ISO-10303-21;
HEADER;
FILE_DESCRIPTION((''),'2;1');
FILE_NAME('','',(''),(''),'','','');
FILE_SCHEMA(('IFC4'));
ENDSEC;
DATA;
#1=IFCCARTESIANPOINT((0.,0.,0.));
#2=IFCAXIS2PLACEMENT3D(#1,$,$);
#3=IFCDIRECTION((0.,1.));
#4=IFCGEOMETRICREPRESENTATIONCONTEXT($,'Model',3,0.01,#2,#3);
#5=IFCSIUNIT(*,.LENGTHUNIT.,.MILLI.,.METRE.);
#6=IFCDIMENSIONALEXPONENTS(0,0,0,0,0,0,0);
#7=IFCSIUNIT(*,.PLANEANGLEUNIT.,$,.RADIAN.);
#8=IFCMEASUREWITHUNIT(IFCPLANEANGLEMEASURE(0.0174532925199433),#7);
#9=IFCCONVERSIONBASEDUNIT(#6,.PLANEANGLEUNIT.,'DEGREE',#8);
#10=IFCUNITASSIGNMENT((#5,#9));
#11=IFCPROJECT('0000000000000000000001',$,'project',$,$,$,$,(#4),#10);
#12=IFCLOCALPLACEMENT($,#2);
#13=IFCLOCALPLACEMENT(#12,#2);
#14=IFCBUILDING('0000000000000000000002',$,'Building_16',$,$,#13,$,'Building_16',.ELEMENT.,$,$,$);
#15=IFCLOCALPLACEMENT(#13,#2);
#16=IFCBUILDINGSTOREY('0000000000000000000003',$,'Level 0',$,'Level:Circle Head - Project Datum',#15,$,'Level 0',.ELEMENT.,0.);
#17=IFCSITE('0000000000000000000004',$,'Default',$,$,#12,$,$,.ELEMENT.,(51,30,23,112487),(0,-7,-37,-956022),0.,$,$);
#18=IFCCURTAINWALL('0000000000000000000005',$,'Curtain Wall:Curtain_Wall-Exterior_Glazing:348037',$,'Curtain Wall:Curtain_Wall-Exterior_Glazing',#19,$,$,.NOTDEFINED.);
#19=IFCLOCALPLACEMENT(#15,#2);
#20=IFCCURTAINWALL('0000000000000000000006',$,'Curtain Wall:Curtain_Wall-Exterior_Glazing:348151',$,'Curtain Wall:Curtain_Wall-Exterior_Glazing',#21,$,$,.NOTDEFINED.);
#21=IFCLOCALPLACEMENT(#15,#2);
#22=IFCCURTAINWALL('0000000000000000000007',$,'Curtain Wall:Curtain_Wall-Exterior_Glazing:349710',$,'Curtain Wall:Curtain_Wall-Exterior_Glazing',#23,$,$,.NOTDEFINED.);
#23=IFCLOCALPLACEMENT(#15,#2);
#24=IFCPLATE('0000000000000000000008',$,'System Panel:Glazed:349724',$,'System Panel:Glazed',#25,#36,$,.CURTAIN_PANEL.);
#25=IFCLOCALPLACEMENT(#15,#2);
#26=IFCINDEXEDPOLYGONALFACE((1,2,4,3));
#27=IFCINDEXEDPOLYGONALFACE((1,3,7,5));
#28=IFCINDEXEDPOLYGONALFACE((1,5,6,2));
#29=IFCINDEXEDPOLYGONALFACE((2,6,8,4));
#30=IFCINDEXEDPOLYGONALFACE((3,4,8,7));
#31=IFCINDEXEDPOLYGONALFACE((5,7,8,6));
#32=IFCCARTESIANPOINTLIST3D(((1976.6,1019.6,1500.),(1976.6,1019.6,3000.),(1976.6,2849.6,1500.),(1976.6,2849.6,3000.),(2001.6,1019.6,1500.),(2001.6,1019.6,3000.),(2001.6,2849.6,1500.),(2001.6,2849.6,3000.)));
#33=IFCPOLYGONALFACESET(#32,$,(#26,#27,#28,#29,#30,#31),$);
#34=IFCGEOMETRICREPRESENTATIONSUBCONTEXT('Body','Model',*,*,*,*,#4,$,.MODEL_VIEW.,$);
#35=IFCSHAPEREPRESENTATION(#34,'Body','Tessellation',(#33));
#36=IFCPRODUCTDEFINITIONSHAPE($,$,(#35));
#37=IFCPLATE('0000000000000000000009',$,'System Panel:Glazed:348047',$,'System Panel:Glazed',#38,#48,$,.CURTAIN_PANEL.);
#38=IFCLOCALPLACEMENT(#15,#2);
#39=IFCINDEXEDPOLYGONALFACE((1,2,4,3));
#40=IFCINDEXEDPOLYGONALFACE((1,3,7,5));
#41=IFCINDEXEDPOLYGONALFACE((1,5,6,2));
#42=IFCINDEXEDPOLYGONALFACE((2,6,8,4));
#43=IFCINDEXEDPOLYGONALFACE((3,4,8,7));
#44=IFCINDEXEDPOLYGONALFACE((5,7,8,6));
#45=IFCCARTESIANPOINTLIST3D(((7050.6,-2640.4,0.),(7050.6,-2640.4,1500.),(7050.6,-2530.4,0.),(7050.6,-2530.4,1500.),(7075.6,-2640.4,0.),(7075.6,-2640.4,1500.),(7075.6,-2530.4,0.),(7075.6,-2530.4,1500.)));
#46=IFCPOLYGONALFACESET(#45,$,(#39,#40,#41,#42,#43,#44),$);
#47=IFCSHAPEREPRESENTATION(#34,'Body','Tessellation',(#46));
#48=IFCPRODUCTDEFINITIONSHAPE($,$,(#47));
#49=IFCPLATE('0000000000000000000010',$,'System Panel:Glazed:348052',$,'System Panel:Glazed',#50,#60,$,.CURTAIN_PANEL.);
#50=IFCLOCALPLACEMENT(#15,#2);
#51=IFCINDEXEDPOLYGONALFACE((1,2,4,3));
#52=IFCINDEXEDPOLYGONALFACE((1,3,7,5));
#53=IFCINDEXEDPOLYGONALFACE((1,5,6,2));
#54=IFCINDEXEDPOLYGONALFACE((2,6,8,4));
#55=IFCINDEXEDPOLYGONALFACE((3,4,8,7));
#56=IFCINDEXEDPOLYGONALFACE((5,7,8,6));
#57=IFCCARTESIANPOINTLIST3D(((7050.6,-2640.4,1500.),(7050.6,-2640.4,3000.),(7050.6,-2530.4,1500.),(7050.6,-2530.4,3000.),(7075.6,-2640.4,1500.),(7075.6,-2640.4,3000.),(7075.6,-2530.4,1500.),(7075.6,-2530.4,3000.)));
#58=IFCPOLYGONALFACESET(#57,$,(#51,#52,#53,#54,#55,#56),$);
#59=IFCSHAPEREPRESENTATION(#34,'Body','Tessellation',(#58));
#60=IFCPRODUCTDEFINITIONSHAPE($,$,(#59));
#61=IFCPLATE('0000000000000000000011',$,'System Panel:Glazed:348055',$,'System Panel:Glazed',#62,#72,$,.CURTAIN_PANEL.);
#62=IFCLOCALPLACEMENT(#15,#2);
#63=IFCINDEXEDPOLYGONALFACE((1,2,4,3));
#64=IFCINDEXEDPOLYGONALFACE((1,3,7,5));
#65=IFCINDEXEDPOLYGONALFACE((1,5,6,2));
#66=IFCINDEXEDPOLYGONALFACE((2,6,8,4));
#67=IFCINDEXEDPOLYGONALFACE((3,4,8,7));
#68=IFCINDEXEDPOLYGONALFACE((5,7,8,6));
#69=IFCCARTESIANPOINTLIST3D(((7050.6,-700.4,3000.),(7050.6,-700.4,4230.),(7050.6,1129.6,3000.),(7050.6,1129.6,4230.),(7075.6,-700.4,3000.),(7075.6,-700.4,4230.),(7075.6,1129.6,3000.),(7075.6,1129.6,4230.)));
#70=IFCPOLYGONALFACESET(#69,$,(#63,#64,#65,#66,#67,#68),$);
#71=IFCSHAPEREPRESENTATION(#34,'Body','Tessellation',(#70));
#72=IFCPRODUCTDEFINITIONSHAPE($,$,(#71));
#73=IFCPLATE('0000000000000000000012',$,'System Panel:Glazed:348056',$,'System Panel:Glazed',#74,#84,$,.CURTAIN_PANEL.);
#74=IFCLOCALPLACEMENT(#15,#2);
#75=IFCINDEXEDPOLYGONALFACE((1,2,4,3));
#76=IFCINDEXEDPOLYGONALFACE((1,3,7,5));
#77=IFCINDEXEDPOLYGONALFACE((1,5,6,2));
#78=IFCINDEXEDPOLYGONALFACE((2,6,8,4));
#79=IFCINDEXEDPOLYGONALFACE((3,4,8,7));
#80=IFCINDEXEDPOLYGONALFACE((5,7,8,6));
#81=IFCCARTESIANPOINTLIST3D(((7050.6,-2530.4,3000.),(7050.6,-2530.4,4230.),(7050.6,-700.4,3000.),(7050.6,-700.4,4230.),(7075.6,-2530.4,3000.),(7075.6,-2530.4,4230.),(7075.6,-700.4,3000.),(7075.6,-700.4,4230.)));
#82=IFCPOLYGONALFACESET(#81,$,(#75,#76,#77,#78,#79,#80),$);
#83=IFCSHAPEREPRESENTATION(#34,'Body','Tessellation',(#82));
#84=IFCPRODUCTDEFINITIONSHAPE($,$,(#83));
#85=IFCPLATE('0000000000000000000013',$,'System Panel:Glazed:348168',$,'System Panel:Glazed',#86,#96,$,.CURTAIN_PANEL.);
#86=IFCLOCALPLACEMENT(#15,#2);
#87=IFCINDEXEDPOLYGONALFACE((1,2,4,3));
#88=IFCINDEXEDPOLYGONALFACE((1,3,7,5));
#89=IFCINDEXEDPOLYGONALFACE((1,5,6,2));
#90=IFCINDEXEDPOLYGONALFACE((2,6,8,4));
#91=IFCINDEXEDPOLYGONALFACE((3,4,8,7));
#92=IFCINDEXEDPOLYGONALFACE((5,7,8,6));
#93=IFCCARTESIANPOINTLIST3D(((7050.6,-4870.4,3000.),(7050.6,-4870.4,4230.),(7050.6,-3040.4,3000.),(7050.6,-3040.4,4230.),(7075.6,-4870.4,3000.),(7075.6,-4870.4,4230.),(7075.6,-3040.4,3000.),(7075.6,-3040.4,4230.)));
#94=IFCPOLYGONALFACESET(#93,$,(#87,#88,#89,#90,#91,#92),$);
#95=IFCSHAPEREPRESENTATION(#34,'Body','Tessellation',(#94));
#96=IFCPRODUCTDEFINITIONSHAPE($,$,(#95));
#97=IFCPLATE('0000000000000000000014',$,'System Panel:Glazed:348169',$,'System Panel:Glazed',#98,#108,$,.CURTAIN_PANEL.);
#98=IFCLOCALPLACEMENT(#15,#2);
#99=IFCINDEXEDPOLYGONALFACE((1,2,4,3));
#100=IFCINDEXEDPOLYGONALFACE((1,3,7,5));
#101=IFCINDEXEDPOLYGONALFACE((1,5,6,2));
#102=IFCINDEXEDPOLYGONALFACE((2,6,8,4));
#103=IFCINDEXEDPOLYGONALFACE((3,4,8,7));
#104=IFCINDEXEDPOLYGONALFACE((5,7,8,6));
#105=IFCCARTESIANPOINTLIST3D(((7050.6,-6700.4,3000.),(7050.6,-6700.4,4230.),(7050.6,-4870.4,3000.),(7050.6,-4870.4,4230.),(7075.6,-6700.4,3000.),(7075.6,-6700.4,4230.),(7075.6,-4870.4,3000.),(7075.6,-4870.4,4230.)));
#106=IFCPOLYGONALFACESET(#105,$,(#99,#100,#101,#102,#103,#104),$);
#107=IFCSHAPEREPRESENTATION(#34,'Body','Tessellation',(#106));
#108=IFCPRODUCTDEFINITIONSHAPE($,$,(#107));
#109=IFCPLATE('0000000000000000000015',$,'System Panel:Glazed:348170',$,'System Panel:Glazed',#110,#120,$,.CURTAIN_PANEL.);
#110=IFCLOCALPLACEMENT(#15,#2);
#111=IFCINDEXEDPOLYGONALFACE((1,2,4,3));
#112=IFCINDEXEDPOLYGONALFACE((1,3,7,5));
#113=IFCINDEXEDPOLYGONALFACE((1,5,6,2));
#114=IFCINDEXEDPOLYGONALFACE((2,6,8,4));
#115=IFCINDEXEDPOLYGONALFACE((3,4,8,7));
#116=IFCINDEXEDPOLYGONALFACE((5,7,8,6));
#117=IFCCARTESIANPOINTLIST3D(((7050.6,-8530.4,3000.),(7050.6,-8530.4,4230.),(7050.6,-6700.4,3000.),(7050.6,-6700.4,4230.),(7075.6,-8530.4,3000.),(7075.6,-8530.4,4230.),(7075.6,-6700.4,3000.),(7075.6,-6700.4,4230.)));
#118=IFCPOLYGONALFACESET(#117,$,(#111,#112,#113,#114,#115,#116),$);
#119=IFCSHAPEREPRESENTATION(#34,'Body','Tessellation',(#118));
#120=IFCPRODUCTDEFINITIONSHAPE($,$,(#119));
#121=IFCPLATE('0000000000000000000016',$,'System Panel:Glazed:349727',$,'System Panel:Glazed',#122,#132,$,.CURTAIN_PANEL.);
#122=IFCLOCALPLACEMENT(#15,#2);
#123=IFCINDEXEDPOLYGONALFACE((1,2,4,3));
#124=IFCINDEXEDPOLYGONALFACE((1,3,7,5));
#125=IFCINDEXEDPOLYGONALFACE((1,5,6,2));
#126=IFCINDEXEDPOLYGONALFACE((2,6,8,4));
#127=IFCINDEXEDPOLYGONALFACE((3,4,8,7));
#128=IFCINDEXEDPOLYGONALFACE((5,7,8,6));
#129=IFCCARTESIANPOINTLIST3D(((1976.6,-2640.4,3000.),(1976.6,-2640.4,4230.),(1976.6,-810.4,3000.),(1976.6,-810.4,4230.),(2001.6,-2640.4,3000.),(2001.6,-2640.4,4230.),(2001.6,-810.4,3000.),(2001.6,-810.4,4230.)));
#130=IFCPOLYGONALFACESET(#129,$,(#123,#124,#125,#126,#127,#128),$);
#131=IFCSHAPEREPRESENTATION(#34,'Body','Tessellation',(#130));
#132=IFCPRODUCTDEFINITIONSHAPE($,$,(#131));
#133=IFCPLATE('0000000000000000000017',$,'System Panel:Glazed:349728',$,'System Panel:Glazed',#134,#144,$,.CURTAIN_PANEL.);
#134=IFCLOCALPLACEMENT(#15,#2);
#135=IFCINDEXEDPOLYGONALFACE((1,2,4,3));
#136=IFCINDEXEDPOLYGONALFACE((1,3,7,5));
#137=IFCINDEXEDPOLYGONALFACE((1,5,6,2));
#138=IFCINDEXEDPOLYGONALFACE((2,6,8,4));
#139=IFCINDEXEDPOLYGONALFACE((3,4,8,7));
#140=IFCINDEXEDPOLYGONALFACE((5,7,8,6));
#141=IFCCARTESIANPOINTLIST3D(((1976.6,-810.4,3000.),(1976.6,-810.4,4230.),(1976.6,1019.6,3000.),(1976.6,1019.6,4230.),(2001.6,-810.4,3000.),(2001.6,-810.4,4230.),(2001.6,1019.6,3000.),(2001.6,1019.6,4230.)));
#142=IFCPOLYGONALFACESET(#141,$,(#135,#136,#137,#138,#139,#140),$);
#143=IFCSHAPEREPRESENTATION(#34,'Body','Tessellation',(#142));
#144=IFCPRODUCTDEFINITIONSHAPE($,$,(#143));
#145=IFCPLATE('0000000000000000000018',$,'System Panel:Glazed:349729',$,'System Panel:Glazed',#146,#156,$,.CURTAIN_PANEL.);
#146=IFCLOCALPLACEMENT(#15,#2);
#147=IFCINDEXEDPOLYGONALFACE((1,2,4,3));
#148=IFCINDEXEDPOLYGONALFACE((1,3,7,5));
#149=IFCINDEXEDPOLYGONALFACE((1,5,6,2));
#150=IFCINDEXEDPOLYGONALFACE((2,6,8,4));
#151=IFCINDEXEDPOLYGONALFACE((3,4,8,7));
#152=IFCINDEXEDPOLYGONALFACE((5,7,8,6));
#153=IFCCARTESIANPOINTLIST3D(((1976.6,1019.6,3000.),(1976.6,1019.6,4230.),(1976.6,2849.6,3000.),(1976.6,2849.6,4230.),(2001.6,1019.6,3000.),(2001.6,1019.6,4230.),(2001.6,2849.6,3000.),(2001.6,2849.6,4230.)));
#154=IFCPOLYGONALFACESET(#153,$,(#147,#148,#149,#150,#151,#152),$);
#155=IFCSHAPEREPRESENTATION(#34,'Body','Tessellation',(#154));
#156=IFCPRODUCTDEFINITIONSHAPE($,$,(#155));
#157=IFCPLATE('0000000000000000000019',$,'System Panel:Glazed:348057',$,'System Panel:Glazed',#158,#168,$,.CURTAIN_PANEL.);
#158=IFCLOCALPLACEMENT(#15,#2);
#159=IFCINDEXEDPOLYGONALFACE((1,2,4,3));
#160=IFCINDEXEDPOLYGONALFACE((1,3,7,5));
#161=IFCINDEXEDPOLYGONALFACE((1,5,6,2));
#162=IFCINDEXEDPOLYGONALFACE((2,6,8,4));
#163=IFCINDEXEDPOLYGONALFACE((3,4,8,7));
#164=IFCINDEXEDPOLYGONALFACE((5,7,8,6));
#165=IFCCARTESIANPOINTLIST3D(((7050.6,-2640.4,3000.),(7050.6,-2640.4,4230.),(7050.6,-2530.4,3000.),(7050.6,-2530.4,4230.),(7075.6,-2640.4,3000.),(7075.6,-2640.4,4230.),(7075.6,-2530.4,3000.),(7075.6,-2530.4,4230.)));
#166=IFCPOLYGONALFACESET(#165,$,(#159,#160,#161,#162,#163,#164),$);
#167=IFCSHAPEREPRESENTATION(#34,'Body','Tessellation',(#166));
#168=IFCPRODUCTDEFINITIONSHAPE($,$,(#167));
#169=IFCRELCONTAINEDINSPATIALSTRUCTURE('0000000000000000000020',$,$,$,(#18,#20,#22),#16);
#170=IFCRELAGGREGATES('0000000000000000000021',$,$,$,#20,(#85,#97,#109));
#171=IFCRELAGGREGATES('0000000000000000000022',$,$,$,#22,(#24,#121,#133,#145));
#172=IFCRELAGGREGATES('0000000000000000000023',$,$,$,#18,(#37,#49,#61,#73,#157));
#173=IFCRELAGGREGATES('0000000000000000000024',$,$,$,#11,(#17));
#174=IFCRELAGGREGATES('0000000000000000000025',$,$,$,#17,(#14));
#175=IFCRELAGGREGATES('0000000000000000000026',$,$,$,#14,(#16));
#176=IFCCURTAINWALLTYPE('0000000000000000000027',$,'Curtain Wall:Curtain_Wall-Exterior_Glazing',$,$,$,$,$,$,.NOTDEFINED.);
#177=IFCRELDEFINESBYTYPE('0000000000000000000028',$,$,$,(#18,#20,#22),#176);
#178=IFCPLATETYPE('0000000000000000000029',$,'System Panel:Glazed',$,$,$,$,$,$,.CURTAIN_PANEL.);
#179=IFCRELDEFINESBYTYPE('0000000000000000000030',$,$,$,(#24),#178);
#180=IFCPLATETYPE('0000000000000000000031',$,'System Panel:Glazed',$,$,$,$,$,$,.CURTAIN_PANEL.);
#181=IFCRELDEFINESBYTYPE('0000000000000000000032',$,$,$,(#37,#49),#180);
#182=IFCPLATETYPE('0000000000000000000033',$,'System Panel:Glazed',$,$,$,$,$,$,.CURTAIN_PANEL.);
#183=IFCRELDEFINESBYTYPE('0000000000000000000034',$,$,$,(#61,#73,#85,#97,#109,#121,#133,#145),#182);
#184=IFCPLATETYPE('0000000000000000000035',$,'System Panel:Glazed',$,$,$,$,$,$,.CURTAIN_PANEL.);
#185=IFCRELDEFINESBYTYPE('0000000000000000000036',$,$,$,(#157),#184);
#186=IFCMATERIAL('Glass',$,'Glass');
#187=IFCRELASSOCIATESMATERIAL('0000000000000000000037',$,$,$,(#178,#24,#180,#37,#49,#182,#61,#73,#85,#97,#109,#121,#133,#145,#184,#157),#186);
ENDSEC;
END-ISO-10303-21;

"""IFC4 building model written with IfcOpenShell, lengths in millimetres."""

from ifc_helpers import new_model, entity, si_unit, converted_unit, direction, frame, origin, place, context, subcontext, project, spatial, indexed_curve, outline, extrude, source, transform, mapped, material, type_object, type_shapes, element, aggregate, save


model = new_model("IFC4")

# Units and contexts
model_context = context("Model", 3, precision=0.01, world=origin(), true_north=direction((0.0, 1.0)))
body_context = subcontext(model_context, "Body", "Model", "MODEL_VIEW")
ifc_project = project(units=[si_unit("LENGTHUNIT", "METRE", prefix="MILLI"), converted_unit("PLANEANGLEUNIT", "DEGREE", entity("IfcPlaneAngleMeasure", 0.0174532925199433), si_unit("PLANEANGLEUNIT", "RADIAN"), dimensions=[0, 0, 0, 0, 0, 0, 0])], contexts=[model_context])

# Site, building, storey
site_placement = place(None, origin())
site = spatial("IfcSite", under=ifc_project, at=site_placement, Name="Default", CompositionType="ELEMENT", RefLatitude=(51, 30, 23, 112487), RefLongitude=(0, -7, -37, -956022), RefElevation=0.0)
building_placement = place(site_placement, origin())
building = spatial("IfcBuilding", under=site, at=building_placement, Name="Building_16", LongName="Building_16", CompositionType="ELEMENT")
storey_placement = place(building_placement, origin())
storey = spatial("IfcBuildingStorey", under=building, at=storey_placement, Name="Level 0", ObjectType="Level:Circle Head - Project Datum", LongName="Level 0", CompositionType="ELEMENT", Elevation=0.0)

# Curtain walls, plate
curtain_wall_type = type_object("IfcCurtainWallType", Name="Curtain Wall:Curtain_Wall-Exterior_Glazing", PredefinedType="NOTDEFINED")
curtain_wall_1_placement = place(storey_placement, origin())
curtain_wall_1 = element("IfcCurtainWall", 1, at=curtain_wall_1_placement, inside=storey, type_object=curtain_wall_type, Name="Curtain Wall:Curtain_Wall-Exterior_Glazing:348037", ObjectType="Curtain Wall:Curtain_Wall-Exterior_Glazing", PredefinedType="NOTDEFINED")
ifc_material_1 = material(Name="Glass", Category="Glass")
plate_type_1 = type_object("IfcPlateType", Name="System Panel:Glazed", PredefinedType="CURTAIN_PANEL", material=ifc_material_1)
shared_shape_1 = source(origin(), body_context, "Body", "SweptSolid", [
    extrude(outline(indexed_curve([(-12.5, -915.0), (12.5, -915.0), (12.5, 915.0), (-12.5, 915.0), (-12.5, -915.0)], self_intersect=False)), frame((0.0, 37.0, 0.0), z_axis=(0.0, 0.0, 1.0), x_axis=(0.0, 1.0, 0.0)), (0.0, 0.0, 1.0), 1500.0),
])
type_shapes(plate_type_1, [shared_shape_1])
curtain_wall_2_placement = place(storey_placement, origin())
curtain_wall_2 = element("IfcCurtainWall", 2, at=curtain_wall_2_placement, inside=storey, type_object=curtain_wall_type, Name="Curtain Wall:Curtain_Wall-Exterior_Glazing:348151", ObjectType="Curtain Wall:Curtain_Wall-Exterior_Glazing", PredefinedType="NOTDEFINED")
curtain_wall_3_placement = place(storey_placement, origin())
curtain_wall_3 = element("IfcCurtainWall", 3, at=curtain_wall_3_placement, inside=storey, type_object=curtain_wall_type, Name="Curtain Wall:Curtain_Wall-Exterior_Glazing:349710", ObjectType="Curtain Wall:Curtain_Wall-Exterior_Glazing", PredefinedType="NOTDEFINED")
plate_1_placement = place(curtain_wall_3_placement, frame((2026.1, 1934.6, 1500.0), z_axis=(0.0, 0.0, 1.0), x_axis=(0.0, 1.0, 0.0)))
plate_1 = element("IfcPlate", 4, at=plate_1_placement, type_object=plate_type_1, material=ifc_material_1, Name="System Panel:Glazed:349724", ObjectType="System Panel:Glazed", PredefinedType="CURTAIN_PANEL", context=body_context, shape_type="MappedRepresentation", body=[
    mapped(shared_shape_1, transform((0.0, 0.0, 0.0), scale=1.0)),
])

# Plates
plate_type_2 = type_object("IfcPlateType", Name="System Panel:Glazed", PredefinedType="CURTAIN_PANEL", material=ifc_material_1)
shared_shape_2 = source(origin(), body_context, "Body", "SweptSolid", [
    extrude(outline(indexed_curve([(-12.5, -55.0), (12.5, -55.0), (12.5, 55.0), (-12.5, 55.0), (-12.5, -55.0)], self_intersect=False)), frame((0.0, 37.0, 0.0), z_axis=(0.0, 0.0, 1.0), x_axis=(0.0, 1.0, 0.0)), (0.0, 0.0, 1.0), 1500.0),
])
type_shapes(plate_type_2, [shared_shape_2])
plate_2_placement = place(curtain_wall_1_placement, frame((7026.1, -2585.4, 0.0), z_axis=(0.0, 0.0, 1.0), x_axis=(0.0, -1.0, 0.0)))
plate_2 = element("IfcPlate", 5, at=plate_2_placement, type_object=plate_type_2, material=ifc_material_1, Name="System Panel:Glazed:348047", ObjectType="System Panel:Glazed", PredefinedType="CURTAIN_PANEL", context=body_context, shape_type="MappedRepresentation", body=[
    mapped(shared_shape_2, transform((0.0, 0.0, 0.0), scale=1.0)),
])
plate_3_placement = place(curtain_wall_1_placement, frame((7026.1, -2585.4, 1500.0), z_axis=(0.0, 0.0, 1.0), x_axis=(0.0, -1.0, 0.0)))
plate_3 = element("IfcPlate", 6, at=plate_3_placement, type_object=plate_type_2, material=ifc_material_1, Name="System Panel:Glazed:348052", ObjectType="System Panel:Glazed", PredefinedType="CURTAIN_PANEL", context=body_context, shape_type="MappedRepresentation", body=[
    mapped(shared_shape_2, transform((0.0, 0.0, 0.0), scale=1.0)),
])
plate_type_3 = type_object("IfcPlateType", Name="System Panel:Glazed", PredefinedType="CURTAIN_PANEL", material=ifc_material_1)
shared_shape_3 = source(origin(), body_context, "Body", "SweptSolid", [
    extrude(outline(indexed_curve([(-12.5, -915.0), (12.5, -915.0), (12.5, 915.0), (-12.5, 915.0), (-12.5, -915.0)], self_intersect=False)), frame((0.0, 37.0, 0.0), z_axis=(0.0, 0.0, 1.0), x_axis=(0.0, 1.0, 0.0)), (0.0, 0.0, 1.0), 1230.0),
])
type_shapes(plate_type_3, [shared_shape_3])
plate_4_placement = place(curtain_wall_1_placement, frame((7026.1, 214.6, 3000.0), z_axis=(0.0, 0.0, 1.0), x_axis=(0.0, -1.0, 0.0)))
plate_4 = element("IfcPlate", 7, at=plate_4_placement, type_object=plate_type_3, material=ifc_material_1, Name="System Panel:Glazed:348055", ObjectType="System Panel:Glazed", PredefinedType="CURTAIN_PANEL", context=body_context, shape_type="MappedRepresentation", body=[
    mapped(shared_shape_3, transform((0.0, 0.0, 0.0), scale=1.0)),
])
plate_5_placement = place(curtain_wall_1_placement, frame((7026.1, -1615.4, 3000.0), z_axis=(0.0, 0.0, 1.0), x_axis=(0.0, -1.0, 0.0)))
plate_5 = element("IfcPlate", 8, at=plate_5_placement, type_object=plate_type_3, material=ifc_material_1, Name="System Panel:Glazed:348056", ObjectType="System Panel:Glazed", PredefinedType="CURTAIN_PANEL", context=body_context, shape_type="MappedRepresentation", body=[
    mapped(shared_shape_3, transform((0.0, 0.0, 0.0), scale=1.0)),
])
plate_6_placement = place(curtain_wall_2_placement, frame((7026.1, -3955.4, 3000.0), z_axis=(0.0, 0.0, 1.0), x_axis=(0.0, -1.0, 0.0)))
plate_6 = element("IfcPlate", 9, at=plate_6_placement, type_object=plate_type_3, material=ifc_material_1, Name="System Panel:Glazed:348168", ObjectType="System Panel:Glazed", PredefinedType="CURTAIN_PANEL", context=body_context, shape_type="MappedRepresentation", body=[
    mapped(shared_shape_3, transform((0.0, 0.0, 0.0), scale=1.0)),
])
plate_7_placement = place(curtain_wall_2_placement, frame((7026.1, -5785.4, 3000.0), z_axis=(0.0, 0.0, 1.0), x_axis=(0.0, -1.0, 0.0)))
plate_7 = element("IfcPlate", 10, at=plate_7_placement, type_object=plate_type_3, material=ifc_material_1, Name="System Panel:Glazed:348169", ObjectType="System Panel:Glazed", PredefinedType="CURTAIN_PANEL", context=body_context, shape_type="MappedRepresentation", body=[
    mapped(shared_shape_3, transform((0.0, 0.0, 0.0), scale=1.0)),
])
plate_8_placement = place(curtain_wall_2_placement, frame((7026.1, -7615.4, 3000.0), z_axis=(0.0, 0.0, 1.0), x_axis=(0.0, -1.0, 0.0)))
plate_8 = element("IfcPlate", 11, at=plate_8_placement, type_object=plate_type_3, material=ifc_material_1, Name="System Panel:Glazed:348170", ObjectType="System Panel:Glazed", PredefinedType="CURTAIN_PANEL", context=body_context, shape_type="MappedRepresentation", body=[
    mapped(shared_shape_3, transform((0.0, 0.0, 0.0), scale=1.0)),
])
aggregate(curtain_wall_2, [plate_6, plate_7, plate_8])
plate_9_placement = place(curtain_wall_3_placement, frame((2026.1, -1725.4, 3000.0), z_axis=(0.0, 0.0, 1.0), x_axis=(0.0, 1.0, 0.0)))
plate_9 = element("IfcPlate", 12, at=plate_9_placement, type_object=plate_type_3, material=ifc_material_1, Name="System Panel:Glazed:349727", ObjectType="System Panel:Glazed", PredefinedType="CURTAIN_PANEL", context=body_context, shape_type="MappedRepresentation", body=[
    mapped(shared_shape_3, transform((0.0, 0.0, 0.0), scale=1.0)),
])
plate_10_placement = place(curtain_wall_3_placement, frame((2026.1, 104.6, 3000.0), z_axis=(0.0, 0.0, 1.0), x_axis=(0.0, 1.0, 0.0)))
plate_10 = element("IfcPlate", 13, at=plate_10_placement, type_object=plate_type_3, material=ifc_material_1, Name="System Panel:Glazed:349728", ObjectType="System Panel:Glazed", PredefinedType="CURTAIN_PANEL", context=body_context, shape_type="MappedRepresentation", body=[
    mapped(shared_shape_3, transform((0.0, 0.0, 0.0), scale=1.0)),
])
plate_11_placement = place(curtain_wall_3_placement, frame((2026.1, 1934.6, 3000.0), z_axis=(0.0, 0.0, 1.0), x_axis=(0.0, 1.0, 0.0)))
plate_11 = element("IfcPlate", 14, at=plate_11_placement, type_object=plate_type_3, material=ifc_material_1, Name="System Panel:Glazed:349729", ObjectType="System Panel:Glazed", PredefinedType="CURTAIN_PANEL", context=body_context, shape_type="MappedRepresentation", body=[
    mapped(shared_shape_3, transform((0.0, 0.0, 0.0), scale=1.0)),
])
aggregate(curtain_wall_3, [plate_1, plate_9, plate_10, plate_11])
plate_type_4 = type_object("IfcPlateType", Name="System Panel:Glazed", PredefinedType="CURTAIN_PANEL", material=ifc_material_1)
shared_shape_4 = source(origin(), body_context, "Body", "SweptSolid", [
    extrude(outline(indexed_curve([(-12.5, -55.0), (12.5, -55.0), (12.5, 55.0), (-12.5, 55.0), (-12.5, -55.0)], self_intersect=False)), frame((0.0, 37.0, 0.0), z_axis=(0.0, 0.0, 1.0), x_axis=(0.0, 1.0, 0.0)), (0.0, 0.0, 1.0), 1230.0),
])
type_shapes(plate_type_4, [shared_shape_4])
plate_12_placement = place(curtain_wall_1_placement, frame((7026.1, -2585.4, 3000.0), z_axis=(0.0, 0.0, 1.0), x_axis=(0.0, -1.0, 0.0)))
plate_12 = element("IfcPlate", 15, at=plate_12_placement, type_object=plate_type_4, material=ifc_material_1, Name="System Panel:Glazed:348057", ObjectType="System Panel:Glazed", PredefinedType="CURTAIN_PANEL", context=body_context, shape_type="MappedRepresentation", body=[
    mapped(shared_shape_4, transform((0.0, 0.0, 0.0), scale=1.0)),
])
aggregate(curtain_wall_1, [plate_2, plate_3, plate_4, plate_5, plate_12])

save(model, "model.ifc")
